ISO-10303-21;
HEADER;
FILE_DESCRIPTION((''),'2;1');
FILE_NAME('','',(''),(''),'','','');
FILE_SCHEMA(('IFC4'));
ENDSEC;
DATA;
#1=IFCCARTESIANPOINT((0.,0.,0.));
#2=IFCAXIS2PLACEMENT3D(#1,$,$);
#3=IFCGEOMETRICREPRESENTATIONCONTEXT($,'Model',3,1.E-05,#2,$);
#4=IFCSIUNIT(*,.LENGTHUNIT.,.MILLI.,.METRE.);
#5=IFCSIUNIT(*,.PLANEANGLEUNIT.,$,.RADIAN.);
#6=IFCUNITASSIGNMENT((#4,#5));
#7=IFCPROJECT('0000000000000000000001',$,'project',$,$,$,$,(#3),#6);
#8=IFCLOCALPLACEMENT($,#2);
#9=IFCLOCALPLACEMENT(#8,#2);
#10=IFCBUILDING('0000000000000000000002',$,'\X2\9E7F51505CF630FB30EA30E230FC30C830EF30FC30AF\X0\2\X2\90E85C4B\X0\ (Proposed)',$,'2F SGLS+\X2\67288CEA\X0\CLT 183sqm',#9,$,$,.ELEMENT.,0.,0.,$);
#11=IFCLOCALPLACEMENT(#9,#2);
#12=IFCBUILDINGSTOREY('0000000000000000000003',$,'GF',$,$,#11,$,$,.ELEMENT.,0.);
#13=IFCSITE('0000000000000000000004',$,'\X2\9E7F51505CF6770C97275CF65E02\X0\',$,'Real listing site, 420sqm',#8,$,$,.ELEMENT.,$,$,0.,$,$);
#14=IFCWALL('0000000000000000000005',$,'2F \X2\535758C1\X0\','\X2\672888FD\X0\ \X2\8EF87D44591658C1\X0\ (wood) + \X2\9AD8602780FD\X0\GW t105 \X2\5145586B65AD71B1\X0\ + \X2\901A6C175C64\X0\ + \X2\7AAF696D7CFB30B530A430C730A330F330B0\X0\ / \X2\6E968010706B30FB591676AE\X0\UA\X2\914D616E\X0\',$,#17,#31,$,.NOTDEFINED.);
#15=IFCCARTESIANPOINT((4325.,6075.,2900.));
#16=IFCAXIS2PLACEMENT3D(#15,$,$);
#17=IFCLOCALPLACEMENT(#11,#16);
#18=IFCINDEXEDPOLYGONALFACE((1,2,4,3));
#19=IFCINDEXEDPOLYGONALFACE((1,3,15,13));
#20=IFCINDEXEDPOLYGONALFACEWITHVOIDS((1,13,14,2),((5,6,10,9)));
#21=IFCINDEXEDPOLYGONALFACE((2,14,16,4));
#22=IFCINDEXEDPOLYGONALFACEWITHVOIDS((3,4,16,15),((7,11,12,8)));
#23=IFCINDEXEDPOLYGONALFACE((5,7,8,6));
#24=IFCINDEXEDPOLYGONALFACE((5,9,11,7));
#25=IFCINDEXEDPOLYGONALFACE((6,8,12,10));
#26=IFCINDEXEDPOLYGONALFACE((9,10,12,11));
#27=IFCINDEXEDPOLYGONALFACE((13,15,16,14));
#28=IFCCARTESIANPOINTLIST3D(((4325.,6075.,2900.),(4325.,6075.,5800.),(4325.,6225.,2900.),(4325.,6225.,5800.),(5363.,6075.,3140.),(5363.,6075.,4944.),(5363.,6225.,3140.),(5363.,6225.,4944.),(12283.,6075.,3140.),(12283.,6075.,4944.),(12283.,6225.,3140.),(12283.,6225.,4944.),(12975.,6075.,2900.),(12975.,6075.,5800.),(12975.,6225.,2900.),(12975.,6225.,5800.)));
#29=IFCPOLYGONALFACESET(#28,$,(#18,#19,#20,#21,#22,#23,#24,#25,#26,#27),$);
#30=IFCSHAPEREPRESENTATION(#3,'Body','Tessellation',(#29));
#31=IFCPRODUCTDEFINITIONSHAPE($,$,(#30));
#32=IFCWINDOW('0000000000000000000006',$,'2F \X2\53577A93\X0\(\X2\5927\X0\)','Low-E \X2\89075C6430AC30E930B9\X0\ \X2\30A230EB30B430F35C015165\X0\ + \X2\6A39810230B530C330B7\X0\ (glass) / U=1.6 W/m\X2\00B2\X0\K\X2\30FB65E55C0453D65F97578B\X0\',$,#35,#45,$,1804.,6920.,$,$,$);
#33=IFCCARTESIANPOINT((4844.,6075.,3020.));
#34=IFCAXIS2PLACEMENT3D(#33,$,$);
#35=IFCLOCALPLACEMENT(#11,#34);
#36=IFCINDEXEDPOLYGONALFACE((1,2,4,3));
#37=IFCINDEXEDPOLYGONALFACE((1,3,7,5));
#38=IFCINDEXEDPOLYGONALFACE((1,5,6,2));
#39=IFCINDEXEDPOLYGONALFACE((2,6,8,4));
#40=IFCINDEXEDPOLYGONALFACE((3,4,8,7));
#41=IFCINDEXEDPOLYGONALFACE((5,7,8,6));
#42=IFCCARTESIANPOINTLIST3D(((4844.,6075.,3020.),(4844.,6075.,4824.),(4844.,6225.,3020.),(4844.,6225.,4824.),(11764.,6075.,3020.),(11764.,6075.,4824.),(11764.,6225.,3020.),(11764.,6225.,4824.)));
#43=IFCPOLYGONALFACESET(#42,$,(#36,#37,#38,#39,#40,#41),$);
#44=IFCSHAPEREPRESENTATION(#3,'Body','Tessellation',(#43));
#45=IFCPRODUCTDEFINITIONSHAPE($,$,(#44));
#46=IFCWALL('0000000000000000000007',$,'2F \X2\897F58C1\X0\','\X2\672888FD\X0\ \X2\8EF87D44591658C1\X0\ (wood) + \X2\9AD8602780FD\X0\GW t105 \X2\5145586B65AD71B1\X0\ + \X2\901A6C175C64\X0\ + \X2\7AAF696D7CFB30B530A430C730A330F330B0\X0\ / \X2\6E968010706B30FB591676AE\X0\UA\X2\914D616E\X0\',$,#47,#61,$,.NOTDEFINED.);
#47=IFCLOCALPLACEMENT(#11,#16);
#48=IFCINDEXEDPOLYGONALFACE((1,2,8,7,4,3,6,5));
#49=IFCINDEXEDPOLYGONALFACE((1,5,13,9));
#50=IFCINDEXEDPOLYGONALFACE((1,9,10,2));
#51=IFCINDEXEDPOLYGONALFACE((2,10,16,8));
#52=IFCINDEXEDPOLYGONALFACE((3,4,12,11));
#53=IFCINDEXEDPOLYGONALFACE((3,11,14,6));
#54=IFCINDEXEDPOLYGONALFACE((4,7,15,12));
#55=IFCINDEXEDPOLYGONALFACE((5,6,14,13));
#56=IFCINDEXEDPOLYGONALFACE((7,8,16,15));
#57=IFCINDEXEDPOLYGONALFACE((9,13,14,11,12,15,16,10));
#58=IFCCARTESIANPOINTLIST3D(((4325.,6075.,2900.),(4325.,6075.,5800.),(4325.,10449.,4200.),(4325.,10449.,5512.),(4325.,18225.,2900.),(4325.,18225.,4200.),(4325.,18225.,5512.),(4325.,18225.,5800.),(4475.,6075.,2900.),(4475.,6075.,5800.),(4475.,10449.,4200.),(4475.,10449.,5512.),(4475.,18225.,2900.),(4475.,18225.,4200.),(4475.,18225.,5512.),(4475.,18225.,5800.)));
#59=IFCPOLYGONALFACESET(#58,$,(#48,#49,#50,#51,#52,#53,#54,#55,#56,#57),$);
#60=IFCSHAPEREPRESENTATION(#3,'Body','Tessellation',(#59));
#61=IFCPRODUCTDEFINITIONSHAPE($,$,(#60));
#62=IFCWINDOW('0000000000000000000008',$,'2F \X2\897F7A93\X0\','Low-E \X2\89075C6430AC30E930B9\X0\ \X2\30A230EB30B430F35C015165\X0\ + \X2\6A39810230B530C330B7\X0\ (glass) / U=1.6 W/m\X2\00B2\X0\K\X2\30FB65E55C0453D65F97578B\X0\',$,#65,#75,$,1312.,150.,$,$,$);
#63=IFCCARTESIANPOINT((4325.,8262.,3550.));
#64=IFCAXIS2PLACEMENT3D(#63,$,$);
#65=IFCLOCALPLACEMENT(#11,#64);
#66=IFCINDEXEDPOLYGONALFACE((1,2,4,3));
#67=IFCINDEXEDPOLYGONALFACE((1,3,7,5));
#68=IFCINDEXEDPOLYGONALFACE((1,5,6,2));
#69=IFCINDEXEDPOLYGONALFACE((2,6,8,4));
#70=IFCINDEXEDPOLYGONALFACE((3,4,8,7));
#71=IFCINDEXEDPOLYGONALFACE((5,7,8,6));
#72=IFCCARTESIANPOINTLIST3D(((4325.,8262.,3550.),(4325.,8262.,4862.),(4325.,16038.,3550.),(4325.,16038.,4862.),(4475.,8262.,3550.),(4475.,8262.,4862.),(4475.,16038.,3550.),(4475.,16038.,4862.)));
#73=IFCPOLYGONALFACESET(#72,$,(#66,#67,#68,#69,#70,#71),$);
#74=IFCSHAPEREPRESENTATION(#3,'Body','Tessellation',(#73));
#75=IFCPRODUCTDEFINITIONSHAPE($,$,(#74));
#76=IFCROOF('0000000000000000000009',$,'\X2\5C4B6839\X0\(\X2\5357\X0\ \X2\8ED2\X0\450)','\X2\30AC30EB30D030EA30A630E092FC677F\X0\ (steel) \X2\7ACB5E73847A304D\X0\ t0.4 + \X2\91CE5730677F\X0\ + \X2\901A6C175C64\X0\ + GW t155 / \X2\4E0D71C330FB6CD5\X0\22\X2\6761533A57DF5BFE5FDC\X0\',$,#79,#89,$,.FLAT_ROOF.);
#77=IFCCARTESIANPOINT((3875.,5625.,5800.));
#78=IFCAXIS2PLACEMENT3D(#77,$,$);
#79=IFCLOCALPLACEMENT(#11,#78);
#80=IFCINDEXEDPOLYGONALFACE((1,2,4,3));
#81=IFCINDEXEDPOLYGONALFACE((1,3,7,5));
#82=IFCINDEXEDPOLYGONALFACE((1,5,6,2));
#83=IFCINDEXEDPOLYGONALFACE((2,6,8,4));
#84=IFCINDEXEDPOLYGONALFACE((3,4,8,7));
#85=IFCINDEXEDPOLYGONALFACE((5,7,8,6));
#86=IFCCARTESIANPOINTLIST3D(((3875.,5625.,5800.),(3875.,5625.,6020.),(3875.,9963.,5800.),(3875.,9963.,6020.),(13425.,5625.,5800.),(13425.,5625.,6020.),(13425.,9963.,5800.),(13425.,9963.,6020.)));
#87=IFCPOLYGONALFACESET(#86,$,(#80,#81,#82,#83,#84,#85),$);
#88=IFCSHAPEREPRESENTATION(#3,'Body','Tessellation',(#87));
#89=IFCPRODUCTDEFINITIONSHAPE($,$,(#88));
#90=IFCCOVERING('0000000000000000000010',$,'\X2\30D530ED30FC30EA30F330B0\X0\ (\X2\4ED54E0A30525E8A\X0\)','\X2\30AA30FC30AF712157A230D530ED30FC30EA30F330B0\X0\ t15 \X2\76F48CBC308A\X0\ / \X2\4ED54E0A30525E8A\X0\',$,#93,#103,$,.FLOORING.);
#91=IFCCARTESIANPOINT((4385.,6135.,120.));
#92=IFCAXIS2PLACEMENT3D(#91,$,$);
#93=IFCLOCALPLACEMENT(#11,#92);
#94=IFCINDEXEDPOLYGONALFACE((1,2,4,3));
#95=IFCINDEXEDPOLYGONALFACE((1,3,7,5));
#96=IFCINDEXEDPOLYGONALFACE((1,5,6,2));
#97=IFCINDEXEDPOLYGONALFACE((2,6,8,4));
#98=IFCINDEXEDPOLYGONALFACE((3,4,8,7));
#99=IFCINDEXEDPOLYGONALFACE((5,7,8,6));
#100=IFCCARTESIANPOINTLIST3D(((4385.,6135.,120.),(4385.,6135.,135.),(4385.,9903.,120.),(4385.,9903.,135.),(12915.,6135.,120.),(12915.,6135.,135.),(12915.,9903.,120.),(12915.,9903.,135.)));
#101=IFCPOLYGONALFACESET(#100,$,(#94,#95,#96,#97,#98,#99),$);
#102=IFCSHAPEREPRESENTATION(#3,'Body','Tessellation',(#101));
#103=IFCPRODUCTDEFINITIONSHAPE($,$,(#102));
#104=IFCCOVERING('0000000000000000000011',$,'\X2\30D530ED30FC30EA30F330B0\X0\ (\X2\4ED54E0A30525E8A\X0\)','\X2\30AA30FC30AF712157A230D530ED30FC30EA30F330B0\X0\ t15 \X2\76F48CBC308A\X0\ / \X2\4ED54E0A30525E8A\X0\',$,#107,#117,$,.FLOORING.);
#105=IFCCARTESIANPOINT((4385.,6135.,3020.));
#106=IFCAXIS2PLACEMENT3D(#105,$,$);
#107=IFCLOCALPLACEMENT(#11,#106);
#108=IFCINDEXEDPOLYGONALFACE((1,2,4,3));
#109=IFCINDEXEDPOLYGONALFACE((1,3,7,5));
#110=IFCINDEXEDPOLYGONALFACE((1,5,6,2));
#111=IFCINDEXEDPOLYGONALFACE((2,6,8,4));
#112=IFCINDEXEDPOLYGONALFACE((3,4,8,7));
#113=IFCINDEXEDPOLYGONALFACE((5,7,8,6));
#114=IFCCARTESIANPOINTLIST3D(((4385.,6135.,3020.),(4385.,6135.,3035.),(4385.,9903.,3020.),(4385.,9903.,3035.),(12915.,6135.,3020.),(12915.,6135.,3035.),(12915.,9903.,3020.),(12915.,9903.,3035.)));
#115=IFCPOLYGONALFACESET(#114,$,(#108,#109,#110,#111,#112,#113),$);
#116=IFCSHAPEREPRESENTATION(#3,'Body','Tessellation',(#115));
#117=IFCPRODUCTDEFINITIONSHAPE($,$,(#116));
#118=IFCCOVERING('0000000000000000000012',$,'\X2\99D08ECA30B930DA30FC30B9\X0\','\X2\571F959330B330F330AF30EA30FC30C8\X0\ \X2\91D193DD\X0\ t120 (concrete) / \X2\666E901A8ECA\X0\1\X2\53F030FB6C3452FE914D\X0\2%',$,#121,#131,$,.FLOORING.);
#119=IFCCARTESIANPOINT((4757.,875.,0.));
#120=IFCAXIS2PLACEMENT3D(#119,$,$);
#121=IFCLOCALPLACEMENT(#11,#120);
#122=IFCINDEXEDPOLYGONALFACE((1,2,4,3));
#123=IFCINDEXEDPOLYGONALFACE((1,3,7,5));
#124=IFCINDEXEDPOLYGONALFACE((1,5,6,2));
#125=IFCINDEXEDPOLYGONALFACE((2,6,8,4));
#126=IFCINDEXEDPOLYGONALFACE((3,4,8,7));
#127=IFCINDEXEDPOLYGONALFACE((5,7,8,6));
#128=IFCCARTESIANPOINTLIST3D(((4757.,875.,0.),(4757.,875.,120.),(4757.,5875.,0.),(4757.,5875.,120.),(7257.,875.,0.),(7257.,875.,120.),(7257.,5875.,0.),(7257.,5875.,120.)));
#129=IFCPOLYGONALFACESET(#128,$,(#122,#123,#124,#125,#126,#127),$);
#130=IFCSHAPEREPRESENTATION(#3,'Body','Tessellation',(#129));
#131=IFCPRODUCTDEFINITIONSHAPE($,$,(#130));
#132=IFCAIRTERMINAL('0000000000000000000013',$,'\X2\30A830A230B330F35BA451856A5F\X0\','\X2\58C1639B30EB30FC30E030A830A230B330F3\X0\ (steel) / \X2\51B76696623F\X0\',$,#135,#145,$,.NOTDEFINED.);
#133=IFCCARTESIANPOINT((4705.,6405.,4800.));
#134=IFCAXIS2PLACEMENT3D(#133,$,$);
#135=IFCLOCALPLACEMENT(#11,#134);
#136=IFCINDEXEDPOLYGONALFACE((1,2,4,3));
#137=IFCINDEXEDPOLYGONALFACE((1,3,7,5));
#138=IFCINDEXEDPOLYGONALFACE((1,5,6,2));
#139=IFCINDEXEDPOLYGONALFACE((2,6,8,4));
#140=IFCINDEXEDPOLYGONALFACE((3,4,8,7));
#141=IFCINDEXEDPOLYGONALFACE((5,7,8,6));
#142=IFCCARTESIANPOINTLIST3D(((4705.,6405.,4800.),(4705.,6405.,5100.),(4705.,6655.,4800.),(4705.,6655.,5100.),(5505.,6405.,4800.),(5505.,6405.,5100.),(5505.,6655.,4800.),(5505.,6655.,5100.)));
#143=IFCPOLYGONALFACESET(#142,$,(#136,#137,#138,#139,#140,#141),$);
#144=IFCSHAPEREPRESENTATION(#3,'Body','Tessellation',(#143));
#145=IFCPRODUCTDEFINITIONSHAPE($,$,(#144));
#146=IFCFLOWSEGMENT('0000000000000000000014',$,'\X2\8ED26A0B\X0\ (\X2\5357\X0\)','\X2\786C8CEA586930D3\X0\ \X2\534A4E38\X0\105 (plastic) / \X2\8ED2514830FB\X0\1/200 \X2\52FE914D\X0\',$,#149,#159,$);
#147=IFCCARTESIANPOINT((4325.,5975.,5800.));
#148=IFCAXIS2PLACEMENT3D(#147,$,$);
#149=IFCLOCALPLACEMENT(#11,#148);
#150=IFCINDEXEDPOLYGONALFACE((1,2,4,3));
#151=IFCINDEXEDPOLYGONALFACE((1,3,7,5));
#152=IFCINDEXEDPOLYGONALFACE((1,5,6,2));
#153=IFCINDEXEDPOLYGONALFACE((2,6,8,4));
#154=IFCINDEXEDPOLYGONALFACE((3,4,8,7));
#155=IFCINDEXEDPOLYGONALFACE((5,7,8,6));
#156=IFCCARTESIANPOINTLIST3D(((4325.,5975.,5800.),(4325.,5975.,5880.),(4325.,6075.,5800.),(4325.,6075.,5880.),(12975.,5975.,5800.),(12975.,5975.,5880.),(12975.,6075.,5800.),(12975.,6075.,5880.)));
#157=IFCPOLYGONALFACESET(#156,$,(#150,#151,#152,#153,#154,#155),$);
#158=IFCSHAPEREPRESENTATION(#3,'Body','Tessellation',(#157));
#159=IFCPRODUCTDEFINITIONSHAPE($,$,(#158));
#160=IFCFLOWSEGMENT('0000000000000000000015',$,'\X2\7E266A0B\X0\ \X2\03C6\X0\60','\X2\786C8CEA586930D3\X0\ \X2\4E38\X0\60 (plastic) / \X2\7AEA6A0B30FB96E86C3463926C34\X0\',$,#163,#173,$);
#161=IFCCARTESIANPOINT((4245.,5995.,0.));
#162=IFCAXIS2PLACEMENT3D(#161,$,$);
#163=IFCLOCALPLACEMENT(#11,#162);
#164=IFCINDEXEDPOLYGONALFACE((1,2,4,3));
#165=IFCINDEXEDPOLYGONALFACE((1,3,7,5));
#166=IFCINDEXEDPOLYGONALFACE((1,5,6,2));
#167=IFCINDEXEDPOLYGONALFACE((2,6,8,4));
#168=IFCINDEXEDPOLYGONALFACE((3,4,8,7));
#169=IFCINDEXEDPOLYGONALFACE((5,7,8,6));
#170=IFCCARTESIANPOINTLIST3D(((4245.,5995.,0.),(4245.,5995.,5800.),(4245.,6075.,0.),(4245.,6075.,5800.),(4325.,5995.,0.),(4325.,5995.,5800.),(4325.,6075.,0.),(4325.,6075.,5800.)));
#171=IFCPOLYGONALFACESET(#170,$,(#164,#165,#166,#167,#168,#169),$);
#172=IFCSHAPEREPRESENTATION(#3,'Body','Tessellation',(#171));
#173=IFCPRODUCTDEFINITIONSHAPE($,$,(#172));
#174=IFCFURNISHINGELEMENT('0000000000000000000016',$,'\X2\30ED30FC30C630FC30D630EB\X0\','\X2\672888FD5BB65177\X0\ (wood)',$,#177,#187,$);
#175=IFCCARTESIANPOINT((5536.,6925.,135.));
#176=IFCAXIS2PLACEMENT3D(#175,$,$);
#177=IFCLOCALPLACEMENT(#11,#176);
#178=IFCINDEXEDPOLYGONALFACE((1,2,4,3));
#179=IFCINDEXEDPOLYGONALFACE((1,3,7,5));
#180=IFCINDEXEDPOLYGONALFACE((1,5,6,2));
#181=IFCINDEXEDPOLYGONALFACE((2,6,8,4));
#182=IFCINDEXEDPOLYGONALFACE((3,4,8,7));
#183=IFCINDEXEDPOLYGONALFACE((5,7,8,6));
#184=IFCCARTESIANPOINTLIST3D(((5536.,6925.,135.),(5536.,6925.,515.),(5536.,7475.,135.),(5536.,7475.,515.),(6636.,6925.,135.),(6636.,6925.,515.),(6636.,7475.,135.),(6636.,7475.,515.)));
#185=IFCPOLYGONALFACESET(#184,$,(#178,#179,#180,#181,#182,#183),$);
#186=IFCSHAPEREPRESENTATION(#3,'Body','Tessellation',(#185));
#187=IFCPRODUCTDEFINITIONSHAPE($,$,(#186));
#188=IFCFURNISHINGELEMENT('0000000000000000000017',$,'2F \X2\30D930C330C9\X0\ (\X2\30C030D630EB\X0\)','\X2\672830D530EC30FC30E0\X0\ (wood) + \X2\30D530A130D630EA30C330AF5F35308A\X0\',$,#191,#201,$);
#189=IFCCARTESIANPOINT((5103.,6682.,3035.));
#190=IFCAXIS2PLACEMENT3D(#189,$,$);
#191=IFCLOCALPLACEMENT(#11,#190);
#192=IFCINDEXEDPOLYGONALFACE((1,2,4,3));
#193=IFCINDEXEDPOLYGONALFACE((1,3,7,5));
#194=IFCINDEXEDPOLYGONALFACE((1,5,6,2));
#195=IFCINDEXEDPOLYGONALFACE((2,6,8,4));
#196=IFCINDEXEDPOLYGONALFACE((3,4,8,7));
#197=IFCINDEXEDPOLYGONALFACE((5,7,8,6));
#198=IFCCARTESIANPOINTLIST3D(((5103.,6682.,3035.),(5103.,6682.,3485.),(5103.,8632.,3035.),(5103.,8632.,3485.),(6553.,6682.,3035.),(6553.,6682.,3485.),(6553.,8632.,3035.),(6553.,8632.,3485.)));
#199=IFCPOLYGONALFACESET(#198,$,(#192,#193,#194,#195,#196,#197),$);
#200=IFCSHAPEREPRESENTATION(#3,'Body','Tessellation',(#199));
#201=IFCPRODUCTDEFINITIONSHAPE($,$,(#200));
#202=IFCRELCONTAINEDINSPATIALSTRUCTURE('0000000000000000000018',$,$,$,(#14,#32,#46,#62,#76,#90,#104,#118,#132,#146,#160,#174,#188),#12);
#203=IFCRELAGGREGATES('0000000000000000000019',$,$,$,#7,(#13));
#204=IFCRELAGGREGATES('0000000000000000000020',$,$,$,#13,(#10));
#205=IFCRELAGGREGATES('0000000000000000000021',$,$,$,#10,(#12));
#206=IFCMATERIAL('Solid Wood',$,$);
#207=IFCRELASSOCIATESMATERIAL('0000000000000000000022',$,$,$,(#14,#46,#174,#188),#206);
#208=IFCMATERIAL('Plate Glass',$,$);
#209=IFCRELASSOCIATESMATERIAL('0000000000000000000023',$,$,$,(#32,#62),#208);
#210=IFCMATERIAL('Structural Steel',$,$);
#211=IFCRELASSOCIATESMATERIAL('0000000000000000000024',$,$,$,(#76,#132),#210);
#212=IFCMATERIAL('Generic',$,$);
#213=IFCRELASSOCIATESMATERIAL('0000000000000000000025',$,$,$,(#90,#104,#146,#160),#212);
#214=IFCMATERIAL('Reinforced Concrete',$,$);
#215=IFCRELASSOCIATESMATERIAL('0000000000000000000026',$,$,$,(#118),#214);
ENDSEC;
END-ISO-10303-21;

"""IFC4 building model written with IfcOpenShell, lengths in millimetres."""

from ifc_helpers import new_model, si_unit, frame, frame_2d, origin, place, context, project, spatial, rectangle, extrude, material, element, fill, save


model = new_model("IFC4")

# Units and contexts
model_context = context("Model", 3, precision=1e-05, world=origin())
ifc_project = project(units=[si_unit("LENGTHUNIT", "METRE", prefix="MILLI"), si_unit("PLANEANGLEUNIT", "RADIAN")], contexts=[model_context])

# Site, building, storey
site_placement = place(None, origin())
site = spatial("IfcSite", under=ifc_project, at=site_placement, Name="鹿児島県霧島市", ObjectType="Real listing site, 420sqm", CompositionType="ELEMENT", RefElevation=0.0)
building_placement = place(site_placement, origin())
building = spatial("IfcBuilding", under=site, at=building_placement, Name="鹿児島・リモートワーク2部屋 (Proposed)", ObjectType="2F SGLS+木質CLT 183sqm", CompositionType="ELEMENT", ElevationOfRefHeight=0.0, ElevationOfTerrain=0.0)
storey_placement = place(building_placement, origin())
storey = spatial("IfcBuildingStorey", under=building, at=storey_placement, Name="GF", CompositionType="ELEMENT", Elevation=0.0)

# Shared definitions
ifc_material_1 = material(Name="Solid Wood")

# Shared definitions
ifc_material_2 = material(Name="Reinforced Concrete")

# Shared definitions
ifc_material_3 = material(Name="Plate Glass")

# Walls, openings, windows
wall_1_placement = place(storey_placement, frame((4325.0, 6075.0, 2900.0)))
wall_1 = element("IfcWall", 1, at=wall_1_placement, inside=storey, material=ifc_material_1, Name="2F 南壁", Description="木製 軸組外壁 (wood) + 高性能GW t105 充填断熱 + 通気層 + 窯業系サイディング / 準耐火・外皮UA配慮", PredefinedType="NOTDEFINED", context=model_context, shape_type="SweptSolid", body=[
    extrude(rectangle(XDim=8650.0, YDim=150.0, at=frame_2d((4325.0, 75.0))), frame((4325.0, 6075.0, 2900.0)), (0.0, 0.0, 1.0), 2900.0),
])
opening_1_placement = place(storey_placement, frame((4844.0, 6075.0, 3020.0)))
opening_1 = element("IfcOpeningElement", 2, at=opening_1_placement, cuts=wall_1, PredefinedType="NOTDEFINED", context=model_context, shape_type="SweptSolid", body=[
    extrude(rectangle(XDim=6920.0, YDim=150.0, at=frame_2d((3460.0, 75.0))), frame((4844.0, 6075.0, 3020.0)), (0.0, 0.0, 1.0), 1804.0),
])
window_1_placement = place(storey_placement, frame((4844.0, 6075.0, 3020.0)))
window_1 = element("IfcWindow", 3, at=window_1_placement, inside=storey, material=ifc_material_3, Name="2F 南窓(大)", Description="Low-E 複層ガラス アルゴン封入 + 樹脂サッシ (glass) / U=1.6 W/m²K・日射取得型", OverallHeight=1804.0, OverallWidth=6920.0, context=model_context, shape_type="SweptSolid", body=[
    extrude(rectangle(XDim=6920.0, YDim=150.0, at=frame_2d((3460.0, 75.0))), frame((4844.0, 6075.0, 3020.0)), (0.0, 0.0, 1.0), 1804.0),
])
fill(opening_1, window_1)
wall_2_placement = place(storey_placement, frame((4325.0, 6075.0, 2900.0)))
wall_2 = element("IfcWall", 4, at=wall_2_placement, inside=storey, material=ifc_material_1, Name="2F 西壁", Description="木製 軸組外壁 (wood) + 高性能GW t105 充填断熱 + 通気層 + 窯業系サイディング / 準耐火・外皮UA配慮", PredefinedType="NOTDEFINED", context=model_context, shape_type="SweptSolid", body=[
    extrude(rectangle(XDim=150.0, YDim=12150.0, at=frame_2d((75.0, 6075.0))), frame((4325.0, 6075.0, 2900.0)), (0.0, 0.0, 1.0), 2900.0),
])
opening_2_placement = place(storey_placement, frame((4325.0, 8262.0, 3550.0)))
opening_2 = element("IfcOpeningElement", 5, at=opening_2_placement, cuts=wall_2, PredefinedType="NOTDEFINED", context=model_context, shape_type="SweptSolid", body=[
    extrude(rectangle(XDim=150.0, YDim=7776.0, at=frame_2d((75.0, 3888.0))), frame((4325.0, 8262.0, 3550.0)), (0.0, 0.0, 1.0), 1312.0),
])
window_2_placement = place(storey_placement, frame((4325.0, 8262.0, 3550.0)))
window_2 = element("IfcWindow", 6, at=window_2_placement, inside=storey, material=ifc_material_3, Name="2F 西窓", Description="Low-E 複層ガラス アルゴン封入 + 樹脂サッシ (glass) / U=1.6 W/m²K・日射取得型", OverallHeight=1312.0, OverallWidth=150.0, context=model_context, shape_type="SweptSolid", body=[
    extrude(rectangle(XDim=150.0, YDim=7776.0, at=frame_2d((75.0, 3888.0))), frame((4325.0, 8262.0, 3550.0)), (0.0, 0.0, 1.0), 1312.0),
])
fill(opening_2, window_2)

# Roof
ifc_material_4 = material(Name="Structural Steel")
for number, where, name in (
    (7, (3875.0, 5625.0, 5800.0), "屋根(南 軒450)"),
):
    element("IfcRoof", number, at=place(storey_placement, frame(where)), inside=storey, material=ifc_material_4, Name=name, Description="ガルバリウム鋼板 (steel) 立平葺き t0.4 + 野地板 + 通気層 + GW t155 / 不燃・法22条区域対応", PredefinedType="FLAT_ROOF", context=model_context, shape_type="SweptSolid", body=[
        extrude(rectangle(XDim=9550.0, YDim=4338.0, at=frame_2d((4775.0, 2169.0))), frame((3875.0, 5625.0, 5800.0)), (0.0, 0.0, 1.0), 220.0),
    ])

# Coverings
ifc_material_5 = material(Name="Generic")
covering_1_placement = place(storey_placement, frame((4385.0, 6135.0, 120.0)))
element("IfcCovering", 8, at=covering_1_placement, inside=storey, material=ifc_material_5, Name="フローリング (仕上げ床)", Description="オーク無垢フローリング t15 直貼り / 仕上げ床", PredefinedType="FLOORING", context=model_context, shape_type="SweptSolid", body=[
    extrude(rectangle(XDim=8530.0, YDim=3768.0, at=frame_2d((4265.0, 1884.0))), frame((4385.0, 6135.0, 120.0)), (0.0, 0.0, 1.0), 15.0),
])
covering_2_placement = place(storey_placement, frame((4385.0, 6135.0, 3020.0)))
element("IfcCovering", 9, at=covering_2_placement, inside=storey, material=ifc_material_5, Name="フローリング (仕上げ床)", Description="オーク無垢フローリング t15 直貼り / 仕上げ床", PredefinedType="FLOORING", context=model_context, shape_type="SweptSolid", body=[
    extrude(rectangle(XDim=8530.0, YDim=3768.0, at=frame_2d((4265.0, 1884.0))), frame((4385.0, 6135.0, 3020.0)), (0.0, 0.0, 1.0), 15.0),
])
covering_3_placement = place(storey_placement, frame((4757.0, 875.0, 0.0)))
element("IfcCovering", 10, at=covering_3_placement, inside=storey, material=ifc_material_2, Name="駐車スペース", Description="土間コンクリート 金鏝 t120 (concrete) / 普通車1台・水勾配2%", PredefinedType="FLOORING", context=model_context, shape_type="SweptSolid", body=[
    extrude(rectangle(XDim=2500.0, YDim=5000.0, at=frame_2d((1250.0, 2500.0))), frame((4757.0, 875.0, 0.0)), (0.0, 0.0, 1.0), 120.0),
])

# Air terminal
air_terminal_placement = place(storey_placement, frame((4705.0, 6405.0, 4800.0)))
element("IfcAirTerminal", 11, at=air_terminal_placement, inside=storey, material=ifc_material_4, Name="エアコン室内機", Description="壁掛ルームエアコン (steel) / 冷暖房", PredefinedType="NOTDEFINED", context=model_context, shape_type="SweptSolid", body=[
    extrude(rectangle(XDim=800.0, YDim=250.0, at=frame_2d((400.0, 125.0))), frame((4705.0, 6405.0, 4800.0)), (0.0, 0.0, 1.0), 300.0),
])

# Flow segments
flow_segment_1_placement = place(storey_placement, frame((4325.0, 5975.0, 5800.0)))
element("IfcFlowSegment", 12, at=flow_segment_1_placement, inside=storey, material=ifc_material_5, Name="軒樋 (南)", Description="硬質塩ビ 半丸105 (plastic) / 軒先・1/200 勾配", context=model_context, shape_type="SweptSolid", body=[
    extrude(rectangle(XDim=8650.0, YDim=100.0, at=frame_2d((4325.0, 50.0))), frame((4325.0, 5975.0, 5800.0)), (0.0, 0.0, 1.0), 80.0),
])
flow_segment_2_placement = place(storey_placement, frame((4245.0, 5995.0, 0.0)))
element("IfcFlowSegment", 13, at=flow_segment_2_placement, inside=storey, material=ifc_material_5, Name="縦樋 φ60", Description="硬質塩ビ 丸60 (plastic) / 竪樋・雨水排水", context=model_context, shape_type="SweptSolid", body=[
    extrude(rectangle(XDim=80.0, YDim=80.0, at=frame_2d((40.0, 40.0))), frame((4245.0, 5995.0, 0.0)), (0.0, 0.0, 1.0), 5800.0),
])

# Furnishing elements
furnishing_1_placement = place(storey_placement, frame((5536.0, 6925.0, 135.0)))
element("IfcFurnishingElement", 14, at=furnishing_1_placement, inside=storey, material=ifc_material_1, Name="ローテーブル", Description="木製家具 (wood)", context=model_context, shape_type="SweptSolid", body=[
    extrude(rectangle(XDim=1100.0, YDim=550.0, at=frame_2d((550.0, 275.0))), frame((5536.0, 6925.0, 135.0)), (0.0, 0.0, 1.0), 380.0),
])
furnishing_2_placement = place(storey_placement, frame((5103.0, 6682.0, 3035.0)))
element("IfcFurnishingElement", 15, at=furnishing_2_placement, inside=storey, material=ifc_material_1, Name="2F ベッド (ダブル)", Description="木フレーム (wood) + ファブリック張り", context=model_context, shape_type="SweptSolid", body=[
    extrude(rectangle(XDim=1450.0, YDim=1950.0, at=frame_2d((725.0, 975.0))), frame((5103.0, 6682.0, 3035.0)), (0.0, 0.0, 1.0), 450.0),
])

save(model, "model.ifc")
